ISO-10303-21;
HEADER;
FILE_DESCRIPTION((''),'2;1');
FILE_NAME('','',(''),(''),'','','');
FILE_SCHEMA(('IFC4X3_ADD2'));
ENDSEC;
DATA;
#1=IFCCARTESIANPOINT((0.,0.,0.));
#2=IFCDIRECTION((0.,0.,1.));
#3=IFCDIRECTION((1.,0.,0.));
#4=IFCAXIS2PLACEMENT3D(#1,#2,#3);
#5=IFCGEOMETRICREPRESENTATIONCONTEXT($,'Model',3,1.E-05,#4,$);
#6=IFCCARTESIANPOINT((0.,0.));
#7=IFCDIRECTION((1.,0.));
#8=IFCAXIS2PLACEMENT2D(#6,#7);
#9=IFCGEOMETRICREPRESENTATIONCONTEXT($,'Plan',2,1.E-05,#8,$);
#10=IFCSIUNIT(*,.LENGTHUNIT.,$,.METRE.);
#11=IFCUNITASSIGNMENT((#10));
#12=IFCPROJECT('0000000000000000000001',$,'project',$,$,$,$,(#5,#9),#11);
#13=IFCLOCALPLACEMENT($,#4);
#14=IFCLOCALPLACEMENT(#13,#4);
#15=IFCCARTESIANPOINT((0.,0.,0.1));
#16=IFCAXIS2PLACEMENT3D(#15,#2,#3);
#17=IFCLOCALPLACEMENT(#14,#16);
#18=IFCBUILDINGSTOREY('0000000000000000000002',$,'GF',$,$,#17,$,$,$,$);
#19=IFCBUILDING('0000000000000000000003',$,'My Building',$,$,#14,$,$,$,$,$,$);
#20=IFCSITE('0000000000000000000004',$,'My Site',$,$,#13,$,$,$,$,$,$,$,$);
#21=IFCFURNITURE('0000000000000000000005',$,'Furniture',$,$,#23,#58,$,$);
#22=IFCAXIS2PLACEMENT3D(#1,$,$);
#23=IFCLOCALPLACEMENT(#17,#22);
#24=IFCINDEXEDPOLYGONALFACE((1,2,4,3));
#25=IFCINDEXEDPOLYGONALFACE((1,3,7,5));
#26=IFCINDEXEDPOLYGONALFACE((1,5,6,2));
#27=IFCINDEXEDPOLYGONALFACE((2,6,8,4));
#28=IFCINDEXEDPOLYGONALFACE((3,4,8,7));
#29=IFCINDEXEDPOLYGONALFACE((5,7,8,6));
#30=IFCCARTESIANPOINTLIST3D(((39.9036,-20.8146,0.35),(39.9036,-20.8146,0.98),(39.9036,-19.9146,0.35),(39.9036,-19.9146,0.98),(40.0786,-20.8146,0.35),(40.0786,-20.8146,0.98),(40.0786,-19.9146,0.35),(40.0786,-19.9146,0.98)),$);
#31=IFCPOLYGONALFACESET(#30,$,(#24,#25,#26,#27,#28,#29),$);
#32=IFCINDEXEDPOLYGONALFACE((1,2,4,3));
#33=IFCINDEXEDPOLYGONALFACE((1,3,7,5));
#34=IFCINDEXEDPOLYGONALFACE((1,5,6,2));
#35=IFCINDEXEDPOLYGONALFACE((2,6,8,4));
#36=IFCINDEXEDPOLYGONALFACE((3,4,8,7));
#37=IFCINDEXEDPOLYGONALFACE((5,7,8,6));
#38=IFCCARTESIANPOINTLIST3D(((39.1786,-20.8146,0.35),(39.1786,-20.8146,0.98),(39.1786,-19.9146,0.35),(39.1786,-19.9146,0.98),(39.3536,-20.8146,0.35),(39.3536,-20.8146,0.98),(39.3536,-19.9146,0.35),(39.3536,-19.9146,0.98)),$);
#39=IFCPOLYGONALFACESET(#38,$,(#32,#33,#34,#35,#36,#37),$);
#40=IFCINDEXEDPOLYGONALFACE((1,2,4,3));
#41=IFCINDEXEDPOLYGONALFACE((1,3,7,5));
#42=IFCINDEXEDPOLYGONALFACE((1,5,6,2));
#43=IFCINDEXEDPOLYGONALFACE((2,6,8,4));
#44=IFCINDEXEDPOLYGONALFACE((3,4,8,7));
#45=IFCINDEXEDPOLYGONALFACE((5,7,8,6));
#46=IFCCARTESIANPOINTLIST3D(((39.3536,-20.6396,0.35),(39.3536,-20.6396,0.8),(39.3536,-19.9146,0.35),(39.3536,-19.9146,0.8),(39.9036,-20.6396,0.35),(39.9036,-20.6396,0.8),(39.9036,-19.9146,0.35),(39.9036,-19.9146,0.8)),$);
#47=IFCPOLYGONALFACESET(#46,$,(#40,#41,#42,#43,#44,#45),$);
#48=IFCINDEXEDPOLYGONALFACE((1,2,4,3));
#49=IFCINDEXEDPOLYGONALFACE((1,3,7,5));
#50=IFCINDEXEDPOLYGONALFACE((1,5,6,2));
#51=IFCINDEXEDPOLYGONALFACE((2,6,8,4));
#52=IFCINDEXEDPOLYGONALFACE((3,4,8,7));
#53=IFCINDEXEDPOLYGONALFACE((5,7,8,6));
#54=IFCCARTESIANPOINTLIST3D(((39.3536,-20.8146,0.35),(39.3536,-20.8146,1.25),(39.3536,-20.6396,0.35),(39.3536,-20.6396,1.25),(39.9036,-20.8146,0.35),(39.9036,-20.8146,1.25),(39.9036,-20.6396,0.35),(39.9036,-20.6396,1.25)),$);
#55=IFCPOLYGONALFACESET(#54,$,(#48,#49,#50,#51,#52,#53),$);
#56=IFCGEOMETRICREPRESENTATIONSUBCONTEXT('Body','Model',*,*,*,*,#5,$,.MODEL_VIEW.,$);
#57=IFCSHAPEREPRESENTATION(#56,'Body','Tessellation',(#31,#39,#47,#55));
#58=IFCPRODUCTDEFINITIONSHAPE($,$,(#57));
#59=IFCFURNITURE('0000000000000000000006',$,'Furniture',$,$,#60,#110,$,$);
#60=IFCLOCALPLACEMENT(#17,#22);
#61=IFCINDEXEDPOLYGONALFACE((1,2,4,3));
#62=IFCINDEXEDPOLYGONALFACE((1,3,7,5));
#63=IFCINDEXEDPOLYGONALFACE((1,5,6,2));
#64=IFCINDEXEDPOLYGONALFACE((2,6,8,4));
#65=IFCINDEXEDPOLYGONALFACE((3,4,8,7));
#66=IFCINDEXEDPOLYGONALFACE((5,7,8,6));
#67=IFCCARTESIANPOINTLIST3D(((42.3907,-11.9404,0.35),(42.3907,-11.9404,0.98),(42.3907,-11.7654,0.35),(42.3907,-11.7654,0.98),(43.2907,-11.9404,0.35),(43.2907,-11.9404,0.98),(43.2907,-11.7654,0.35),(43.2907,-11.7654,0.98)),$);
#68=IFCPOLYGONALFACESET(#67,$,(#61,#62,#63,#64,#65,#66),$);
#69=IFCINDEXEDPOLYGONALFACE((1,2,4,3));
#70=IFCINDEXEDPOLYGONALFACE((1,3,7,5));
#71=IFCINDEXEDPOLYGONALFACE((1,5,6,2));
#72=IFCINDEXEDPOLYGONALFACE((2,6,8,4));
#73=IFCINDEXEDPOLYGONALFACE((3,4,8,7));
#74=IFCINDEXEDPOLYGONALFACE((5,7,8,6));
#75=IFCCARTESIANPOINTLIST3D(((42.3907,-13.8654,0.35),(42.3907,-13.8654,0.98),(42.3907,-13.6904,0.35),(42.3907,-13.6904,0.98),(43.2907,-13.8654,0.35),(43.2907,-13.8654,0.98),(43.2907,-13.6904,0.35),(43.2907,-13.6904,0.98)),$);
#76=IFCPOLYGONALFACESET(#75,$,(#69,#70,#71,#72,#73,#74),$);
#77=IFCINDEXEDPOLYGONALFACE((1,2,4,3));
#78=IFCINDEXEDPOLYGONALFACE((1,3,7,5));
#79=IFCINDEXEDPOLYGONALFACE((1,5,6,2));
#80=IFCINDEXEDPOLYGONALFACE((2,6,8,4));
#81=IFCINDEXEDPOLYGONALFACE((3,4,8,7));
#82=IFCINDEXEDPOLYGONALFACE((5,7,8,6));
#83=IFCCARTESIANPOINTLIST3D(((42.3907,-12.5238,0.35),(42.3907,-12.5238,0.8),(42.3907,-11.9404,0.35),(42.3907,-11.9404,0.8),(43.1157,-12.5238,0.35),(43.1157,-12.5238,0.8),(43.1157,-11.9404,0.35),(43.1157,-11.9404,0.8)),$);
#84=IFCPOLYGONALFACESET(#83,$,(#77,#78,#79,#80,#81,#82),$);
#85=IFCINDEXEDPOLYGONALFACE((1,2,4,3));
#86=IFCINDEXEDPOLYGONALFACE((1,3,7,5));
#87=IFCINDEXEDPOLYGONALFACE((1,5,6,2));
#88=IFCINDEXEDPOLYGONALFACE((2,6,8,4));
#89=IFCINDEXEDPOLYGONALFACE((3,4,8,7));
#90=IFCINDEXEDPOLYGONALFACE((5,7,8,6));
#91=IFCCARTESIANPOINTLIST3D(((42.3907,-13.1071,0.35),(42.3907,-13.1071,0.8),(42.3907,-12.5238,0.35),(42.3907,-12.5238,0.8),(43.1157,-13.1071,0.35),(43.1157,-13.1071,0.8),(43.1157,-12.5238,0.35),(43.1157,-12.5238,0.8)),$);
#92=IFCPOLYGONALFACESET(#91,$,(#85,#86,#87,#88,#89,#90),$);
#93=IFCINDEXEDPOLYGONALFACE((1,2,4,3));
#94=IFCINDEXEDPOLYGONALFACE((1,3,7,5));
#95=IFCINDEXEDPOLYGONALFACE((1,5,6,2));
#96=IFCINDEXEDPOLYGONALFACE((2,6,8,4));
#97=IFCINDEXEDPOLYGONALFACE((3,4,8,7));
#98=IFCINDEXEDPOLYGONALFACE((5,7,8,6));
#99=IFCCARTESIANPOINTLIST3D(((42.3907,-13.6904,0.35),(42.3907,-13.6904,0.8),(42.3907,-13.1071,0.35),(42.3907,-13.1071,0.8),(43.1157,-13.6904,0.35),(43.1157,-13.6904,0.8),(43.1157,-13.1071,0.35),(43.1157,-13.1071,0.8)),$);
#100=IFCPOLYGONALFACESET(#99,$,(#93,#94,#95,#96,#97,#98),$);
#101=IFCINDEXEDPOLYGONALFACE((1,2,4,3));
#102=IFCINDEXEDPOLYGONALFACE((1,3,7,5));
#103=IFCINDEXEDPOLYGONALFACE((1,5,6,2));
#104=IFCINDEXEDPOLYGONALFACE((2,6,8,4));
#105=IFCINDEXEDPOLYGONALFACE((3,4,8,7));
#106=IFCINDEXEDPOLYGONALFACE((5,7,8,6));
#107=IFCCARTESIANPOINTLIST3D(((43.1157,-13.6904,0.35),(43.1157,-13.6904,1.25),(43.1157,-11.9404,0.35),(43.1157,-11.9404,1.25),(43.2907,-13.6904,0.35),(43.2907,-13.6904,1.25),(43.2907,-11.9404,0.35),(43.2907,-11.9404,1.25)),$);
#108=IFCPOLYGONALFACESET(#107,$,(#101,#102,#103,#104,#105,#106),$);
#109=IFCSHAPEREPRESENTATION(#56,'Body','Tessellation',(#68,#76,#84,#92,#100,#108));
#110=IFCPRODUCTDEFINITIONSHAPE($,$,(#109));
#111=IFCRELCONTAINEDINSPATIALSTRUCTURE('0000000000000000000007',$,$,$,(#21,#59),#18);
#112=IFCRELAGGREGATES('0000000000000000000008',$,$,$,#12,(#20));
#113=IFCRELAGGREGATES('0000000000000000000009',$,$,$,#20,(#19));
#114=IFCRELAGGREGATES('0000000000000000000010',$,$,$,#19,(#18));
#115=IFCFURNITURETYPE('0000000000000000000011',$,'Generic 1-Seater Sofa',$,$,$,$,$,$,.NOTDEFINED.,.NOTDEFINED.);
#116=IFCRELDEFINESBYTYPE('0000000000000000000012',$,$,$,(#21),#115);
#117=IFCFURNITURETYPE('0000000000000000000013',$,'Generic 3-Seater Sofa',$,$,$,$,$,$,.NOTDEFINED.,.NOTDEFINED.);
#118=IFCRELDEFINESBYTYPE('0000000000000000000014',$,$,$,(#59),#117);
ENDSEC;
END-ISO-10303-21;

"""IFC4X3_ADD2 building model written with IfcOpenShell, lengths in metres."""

from ifc_helpers import new_model, entity, si_unit, frame, origin_with_axes, origin_2d_with_axis, place, context, subcontext, project, spatial, line, indexed_curve, outline, extrude, shape, source, transform, mapped, type_object, type_shapes, element, save


model = new_model("IFC4X3_ADD2")

# Units and contexts
model_context = context("Model", 3, precision=1e-05, world=origin_with_axes())
plan_context = context("Plan", 2, precision=1e-05, world=origin_2d_with_axis())
body_context_1 = subcontext(model_context, "Body", "Model", "MODEL_VIEW")
body_context_2 = subcontext(plan_context, "Body", "Plan", "PLAN_VIEW")
ifc_project = project(units=[si_unit("LENGTHUNIT", "METRE")], contexts=[model_context, plan_context])

# Site, building, storey
site_placement = place(None, origin_with_axes())
site = spatial("IfcSite", under=ifc_project, at=site_placement, Name="My Site")
building_placement = place(site_placement, origin_with_axes())
building = spatial("IfcBuilding", under=site, at=building_placement, Name="My Building")
storey_placement = place(building_placement, frame((0.0, 0.0, 0.1), z_axis=(0.0, 0.0, 1.0), x_axis=(1.0, 0.0, 0.0)))
storey = spatial("IfcBuildingStorey", under=building, at=storey_placement, Name="GF")

# Furniture
furniture_type_1 = type_object("IfcFurnitureType", Name="Generic 1-Seater Sofa", AssemblyPlace="NOTDEFINED", PredefinedType="NOTDEFINED")
shared_shape_1 = source(origin_with_axes(), body_context_1, "Body", "SweptSolid", [
    extrude(outline(indexed_curve([(0.0, 0.0), (0.175, 0.0), (0.175, 0.9), (0.0, 0.9)], segments=[line(4, 1), line(1, 2), line(2, 3), line(3, 4)], self_intersect=False)), frame((-0.45, -0.9, 0.0), z_axis=(0.0, 0.0, 1.0), x_axis=(1.0, 0.0, 0.0)), (0.0, 0.0, 1.0), 0.63),
    extrude(outline(indexed_curve([(0.0, 0.0), (0.175, 0.0), (0.175, 0.9), (0.0, 0.9)], segments=[line(1, 2, 3, 4, 1)])), frame((0.275, -0.9, 0.0), z_axis=(0.0, 0.0, 1.0), x_axis=(1.0, 0.0, 0.0)), (0.0, 0.0, 1.0), 0.63),
    extrude(outline(indexed_curve([(0.175, 0.0), (0.725, 0.0), (0.725, 0.725), (0.175, 0.725)], segments=[line(1, 2, 3, 4, 1)])), frame((-0.45, -0.9, 0.0), z_axis=(0.0, 0.0, 1.0), x_axis=(1.0, 0.0, 0.0)), (0.0, 0.0, 1.0), 0.45),
    extrude(outline(indexed_curve([(0.175, 0.725), (0.725, 0.725), (0.725, 0.9), (0.175, 0.9)], segments=[line(1, 2, 3, 4, 1)])), frame((-0.45, -0.9, 0.0), z_axis=(0.0, 0.0, 1.0), x_axis=(1.0, 0.0, 0.0)), (0.0, 0.0, 1.0), 0.9),
])
shared_shape_2 = source(origin_with_axes(), body_context_2, "Body", "Annotation2D", [
    entity("IfcGeometricCurveSet", [entity("IfcIndexedPolyCurve", entity("IfcCartesianPointList2D", [[0.275, -0.175], [0.275, -0.9], [0.45, -0.9], [0.45, 0.0], [0.275, 0.0], [0.275, -0.9], [-0.275, -0.9], [-0.275, 0.0], [-0.275, -0.175], [0.275, -0.175], [0.275, 0.0], [-0.275, 0.0], [-0.45, 0.0], [-0.45, -0.9], [-0.275, -0.9], [-0.275, -0.175]]))]),
])
type_shapes(furniture_type_1, [shared_shape_1, shared_shape_2])
for number, where, z_axis, x_axis, name in (
    (1, (39.6286, -20.8146, 0.35), (0.0, 0.0, 1.0), (-1.0, 0.0, 0.0), "Furniture"),
):
    element("IfcFurniture", number, at=place(storey_placement, frame(where, z_axis=z_axis, x_axis=x_axis)), inside=storey, type_object=furniture_type_1, Name=name, shapes=[
        shape(body_context_1, "Body", "MappedRepresentation", [mapped(shared_shape_1, transform((0.0, 0.0, 0.0), x_axis=(1.0, 0.0, 0.0), y_axis=(0.0, 1.0, 0.0), z_axis=(0.0, 0.0, 1.0), scale=1.0))]),
        shape(body_context_2, "Body", "MappedRepresentation", [mapped(shared_shape_2, transform((0.0, 0.0, 0.0), x_axis=(1.0, 0.0, 0.0), y_axis=(0.0, 1.0, 0.0), z_axis=(0.0, 0.0, 1.0), scale=1.0))]),
    ])
furniture_type_2 = type_object("IfcFurnitureType", Name="Generic 3-Seater Sofa", AssemblyPlace="NOTDEFINED", PredefinedType="NOTDEFINED")
shared_shape_3 = source(origin_with_axes(), body_context_1, "Body", "SweptSolid", [
    extrude(outline(indexed_curve([(0.0, 0.0), (0.175, 0.0), (0.175, 0.9), (0.0, 0.9)], segments=[line(4, 1), line(1, 2), line(2, 3), line(3, 4)], self_intersect=False)), frame((-1.05, -0.9, 0.0), z_axis=(0.0, 0.0, 1.0), x_axis=(1.0, 0.0, 0.0)), (0.0, 0.0, 1.0), 0.63),
    extrude(outline(indexed_curve([(0.0, 0.0), (0.175, 0.0), (0.175, 0.9), (0.0, 0.9)], segments=[line(1, 2, 3, 4, 1)])), frame((0.875, -0.9, 0.0), z_axis=(0.0, 0.0, 1.0), x_axis=(1.0, 0.0, 0.0)), (0.0, 0.0, 1.0), 0.63),
    extrude(outline(indexed_curve([(0.175, 0.0), (0.7583, 0.0), (0.7583, 0.725), (0.175, 0.725)], segments=[line(1, 2, 3, 4, 1)])), frame((-1.05, -0.9, 0.0), z_axis=(0.0, 0.0, 1.0), x_axis=(1.0, 0.0, 0.0)), (0.0, 0.0, 1.0), 0.45),
    extrude(outline(indexed_curve([(0.7583, 0.0), (1.3417, 0.0), (1.3417, 0.725), (0.7583, 0.725)], segments=[line(1, 2, 3, 4, 1)])), frame((-1.05, -0.9, 0.0), z_axis=(0.0, 0.0, 1.0), x_axis=(1.0, 0.0, 0.0)), (0.0, 0.0, 1.0), 0.45),
    extrude(outline(indexed_curve([(1.3417, 0.0), (1.925, 0.0), (1.925, 0.725), (1.3417, 0.725)], segments=[line(1, 2, 3, 4, 1)])), frame((-1.05, -0.9, 0.0), z_axis=(0.0, 0.0, 1.0), x_axis=(1.0, 0.0, 0.0)), (0.0, 0.0, 1.0), 0.45),
    extrude(outline(indexed_curve([(0.175, 0.725), (1.925, 0.725), (1.925, 0.9), (0.175, 0.9)], segments=[line(1, 2, 3, 4, 1)])), frame((-1.05, -0.9, 0.0), z_axis=(0.0, 0.0, 1.0), x_axis=(1.0, 0.0, 0.0)), (0.0, 0.0, 1.0), 0.9),
])
shared_shape_4 = source(origin_with_axes(), body_context_2, "Body", "Annotation2D", [
    entity("IfcGeometricCurveSet", [entity("IfcIndexedPolyCurve", entity("IfcCartesianPointList2D", [[0.2917, -0.175], [0.2917, -0.9], [0.875, -0.9], [0.875, -0.175], [-0.875, -0.175], [-0.875, 0.0], [0.875, 0.0], [1.05, 0.0], [1.05, -0.9], [0.875, -0.9], [0.875, 0.0], [0.875, -0.175], [0.2917, -0.175], [-0.2917, -0.175], [-0.2917, -0.9], [-0.875, -0.9], [-0.875, 0.0], [-1.05, 0.0], [-1.05, -0.9], [-0.875, -0.9], [-0.875, -0.175], [-0.2917, -0.175]])), entity("IfcIndexedPolyCurve", entity("IfcCartesianPointList2D", [[0.2917, -0.9], [-0.2917, -0.9]]))]),
])
type_shapes(furniture_type_2, [shared_shape_3, shared_shape_4])
furniture_placement = place(storey_placement, frame((43.2907, -12.8154, 0.35), z_axis=(0.0, 0.0, 1.0), x_axis=(0.0, -1.0, 0.0)))
element("IfcFurniture", 2, at=furniture_placement, inside=storey, type_object=furniture_type_2, Name="Furniture", shapes=[
    shape(body_context_1, "Body", "MappedRepresentation", [mapped(shared_shape_3, transform((0.0, 0.0, 0.0), x_axis=(1.0, 0.0, 0.0), y_axis=(0.0, 1.0, 0.0), z_axis=(0.0, 0.0, 1.0), scale=1.0))]),
    shape(body_context_2, "Body", "MappedRepresentation", [mapped(shared_shape_4, transform((0.0, 0.0, 0.0), x_axis=(1.0, 0.0, 0.0), y_axis=(0.0, 1.0, 0.0), z_axis=(0.0, 0.0, 1.0), scale=1.0))]),
])

save(model, "model.ifc")
